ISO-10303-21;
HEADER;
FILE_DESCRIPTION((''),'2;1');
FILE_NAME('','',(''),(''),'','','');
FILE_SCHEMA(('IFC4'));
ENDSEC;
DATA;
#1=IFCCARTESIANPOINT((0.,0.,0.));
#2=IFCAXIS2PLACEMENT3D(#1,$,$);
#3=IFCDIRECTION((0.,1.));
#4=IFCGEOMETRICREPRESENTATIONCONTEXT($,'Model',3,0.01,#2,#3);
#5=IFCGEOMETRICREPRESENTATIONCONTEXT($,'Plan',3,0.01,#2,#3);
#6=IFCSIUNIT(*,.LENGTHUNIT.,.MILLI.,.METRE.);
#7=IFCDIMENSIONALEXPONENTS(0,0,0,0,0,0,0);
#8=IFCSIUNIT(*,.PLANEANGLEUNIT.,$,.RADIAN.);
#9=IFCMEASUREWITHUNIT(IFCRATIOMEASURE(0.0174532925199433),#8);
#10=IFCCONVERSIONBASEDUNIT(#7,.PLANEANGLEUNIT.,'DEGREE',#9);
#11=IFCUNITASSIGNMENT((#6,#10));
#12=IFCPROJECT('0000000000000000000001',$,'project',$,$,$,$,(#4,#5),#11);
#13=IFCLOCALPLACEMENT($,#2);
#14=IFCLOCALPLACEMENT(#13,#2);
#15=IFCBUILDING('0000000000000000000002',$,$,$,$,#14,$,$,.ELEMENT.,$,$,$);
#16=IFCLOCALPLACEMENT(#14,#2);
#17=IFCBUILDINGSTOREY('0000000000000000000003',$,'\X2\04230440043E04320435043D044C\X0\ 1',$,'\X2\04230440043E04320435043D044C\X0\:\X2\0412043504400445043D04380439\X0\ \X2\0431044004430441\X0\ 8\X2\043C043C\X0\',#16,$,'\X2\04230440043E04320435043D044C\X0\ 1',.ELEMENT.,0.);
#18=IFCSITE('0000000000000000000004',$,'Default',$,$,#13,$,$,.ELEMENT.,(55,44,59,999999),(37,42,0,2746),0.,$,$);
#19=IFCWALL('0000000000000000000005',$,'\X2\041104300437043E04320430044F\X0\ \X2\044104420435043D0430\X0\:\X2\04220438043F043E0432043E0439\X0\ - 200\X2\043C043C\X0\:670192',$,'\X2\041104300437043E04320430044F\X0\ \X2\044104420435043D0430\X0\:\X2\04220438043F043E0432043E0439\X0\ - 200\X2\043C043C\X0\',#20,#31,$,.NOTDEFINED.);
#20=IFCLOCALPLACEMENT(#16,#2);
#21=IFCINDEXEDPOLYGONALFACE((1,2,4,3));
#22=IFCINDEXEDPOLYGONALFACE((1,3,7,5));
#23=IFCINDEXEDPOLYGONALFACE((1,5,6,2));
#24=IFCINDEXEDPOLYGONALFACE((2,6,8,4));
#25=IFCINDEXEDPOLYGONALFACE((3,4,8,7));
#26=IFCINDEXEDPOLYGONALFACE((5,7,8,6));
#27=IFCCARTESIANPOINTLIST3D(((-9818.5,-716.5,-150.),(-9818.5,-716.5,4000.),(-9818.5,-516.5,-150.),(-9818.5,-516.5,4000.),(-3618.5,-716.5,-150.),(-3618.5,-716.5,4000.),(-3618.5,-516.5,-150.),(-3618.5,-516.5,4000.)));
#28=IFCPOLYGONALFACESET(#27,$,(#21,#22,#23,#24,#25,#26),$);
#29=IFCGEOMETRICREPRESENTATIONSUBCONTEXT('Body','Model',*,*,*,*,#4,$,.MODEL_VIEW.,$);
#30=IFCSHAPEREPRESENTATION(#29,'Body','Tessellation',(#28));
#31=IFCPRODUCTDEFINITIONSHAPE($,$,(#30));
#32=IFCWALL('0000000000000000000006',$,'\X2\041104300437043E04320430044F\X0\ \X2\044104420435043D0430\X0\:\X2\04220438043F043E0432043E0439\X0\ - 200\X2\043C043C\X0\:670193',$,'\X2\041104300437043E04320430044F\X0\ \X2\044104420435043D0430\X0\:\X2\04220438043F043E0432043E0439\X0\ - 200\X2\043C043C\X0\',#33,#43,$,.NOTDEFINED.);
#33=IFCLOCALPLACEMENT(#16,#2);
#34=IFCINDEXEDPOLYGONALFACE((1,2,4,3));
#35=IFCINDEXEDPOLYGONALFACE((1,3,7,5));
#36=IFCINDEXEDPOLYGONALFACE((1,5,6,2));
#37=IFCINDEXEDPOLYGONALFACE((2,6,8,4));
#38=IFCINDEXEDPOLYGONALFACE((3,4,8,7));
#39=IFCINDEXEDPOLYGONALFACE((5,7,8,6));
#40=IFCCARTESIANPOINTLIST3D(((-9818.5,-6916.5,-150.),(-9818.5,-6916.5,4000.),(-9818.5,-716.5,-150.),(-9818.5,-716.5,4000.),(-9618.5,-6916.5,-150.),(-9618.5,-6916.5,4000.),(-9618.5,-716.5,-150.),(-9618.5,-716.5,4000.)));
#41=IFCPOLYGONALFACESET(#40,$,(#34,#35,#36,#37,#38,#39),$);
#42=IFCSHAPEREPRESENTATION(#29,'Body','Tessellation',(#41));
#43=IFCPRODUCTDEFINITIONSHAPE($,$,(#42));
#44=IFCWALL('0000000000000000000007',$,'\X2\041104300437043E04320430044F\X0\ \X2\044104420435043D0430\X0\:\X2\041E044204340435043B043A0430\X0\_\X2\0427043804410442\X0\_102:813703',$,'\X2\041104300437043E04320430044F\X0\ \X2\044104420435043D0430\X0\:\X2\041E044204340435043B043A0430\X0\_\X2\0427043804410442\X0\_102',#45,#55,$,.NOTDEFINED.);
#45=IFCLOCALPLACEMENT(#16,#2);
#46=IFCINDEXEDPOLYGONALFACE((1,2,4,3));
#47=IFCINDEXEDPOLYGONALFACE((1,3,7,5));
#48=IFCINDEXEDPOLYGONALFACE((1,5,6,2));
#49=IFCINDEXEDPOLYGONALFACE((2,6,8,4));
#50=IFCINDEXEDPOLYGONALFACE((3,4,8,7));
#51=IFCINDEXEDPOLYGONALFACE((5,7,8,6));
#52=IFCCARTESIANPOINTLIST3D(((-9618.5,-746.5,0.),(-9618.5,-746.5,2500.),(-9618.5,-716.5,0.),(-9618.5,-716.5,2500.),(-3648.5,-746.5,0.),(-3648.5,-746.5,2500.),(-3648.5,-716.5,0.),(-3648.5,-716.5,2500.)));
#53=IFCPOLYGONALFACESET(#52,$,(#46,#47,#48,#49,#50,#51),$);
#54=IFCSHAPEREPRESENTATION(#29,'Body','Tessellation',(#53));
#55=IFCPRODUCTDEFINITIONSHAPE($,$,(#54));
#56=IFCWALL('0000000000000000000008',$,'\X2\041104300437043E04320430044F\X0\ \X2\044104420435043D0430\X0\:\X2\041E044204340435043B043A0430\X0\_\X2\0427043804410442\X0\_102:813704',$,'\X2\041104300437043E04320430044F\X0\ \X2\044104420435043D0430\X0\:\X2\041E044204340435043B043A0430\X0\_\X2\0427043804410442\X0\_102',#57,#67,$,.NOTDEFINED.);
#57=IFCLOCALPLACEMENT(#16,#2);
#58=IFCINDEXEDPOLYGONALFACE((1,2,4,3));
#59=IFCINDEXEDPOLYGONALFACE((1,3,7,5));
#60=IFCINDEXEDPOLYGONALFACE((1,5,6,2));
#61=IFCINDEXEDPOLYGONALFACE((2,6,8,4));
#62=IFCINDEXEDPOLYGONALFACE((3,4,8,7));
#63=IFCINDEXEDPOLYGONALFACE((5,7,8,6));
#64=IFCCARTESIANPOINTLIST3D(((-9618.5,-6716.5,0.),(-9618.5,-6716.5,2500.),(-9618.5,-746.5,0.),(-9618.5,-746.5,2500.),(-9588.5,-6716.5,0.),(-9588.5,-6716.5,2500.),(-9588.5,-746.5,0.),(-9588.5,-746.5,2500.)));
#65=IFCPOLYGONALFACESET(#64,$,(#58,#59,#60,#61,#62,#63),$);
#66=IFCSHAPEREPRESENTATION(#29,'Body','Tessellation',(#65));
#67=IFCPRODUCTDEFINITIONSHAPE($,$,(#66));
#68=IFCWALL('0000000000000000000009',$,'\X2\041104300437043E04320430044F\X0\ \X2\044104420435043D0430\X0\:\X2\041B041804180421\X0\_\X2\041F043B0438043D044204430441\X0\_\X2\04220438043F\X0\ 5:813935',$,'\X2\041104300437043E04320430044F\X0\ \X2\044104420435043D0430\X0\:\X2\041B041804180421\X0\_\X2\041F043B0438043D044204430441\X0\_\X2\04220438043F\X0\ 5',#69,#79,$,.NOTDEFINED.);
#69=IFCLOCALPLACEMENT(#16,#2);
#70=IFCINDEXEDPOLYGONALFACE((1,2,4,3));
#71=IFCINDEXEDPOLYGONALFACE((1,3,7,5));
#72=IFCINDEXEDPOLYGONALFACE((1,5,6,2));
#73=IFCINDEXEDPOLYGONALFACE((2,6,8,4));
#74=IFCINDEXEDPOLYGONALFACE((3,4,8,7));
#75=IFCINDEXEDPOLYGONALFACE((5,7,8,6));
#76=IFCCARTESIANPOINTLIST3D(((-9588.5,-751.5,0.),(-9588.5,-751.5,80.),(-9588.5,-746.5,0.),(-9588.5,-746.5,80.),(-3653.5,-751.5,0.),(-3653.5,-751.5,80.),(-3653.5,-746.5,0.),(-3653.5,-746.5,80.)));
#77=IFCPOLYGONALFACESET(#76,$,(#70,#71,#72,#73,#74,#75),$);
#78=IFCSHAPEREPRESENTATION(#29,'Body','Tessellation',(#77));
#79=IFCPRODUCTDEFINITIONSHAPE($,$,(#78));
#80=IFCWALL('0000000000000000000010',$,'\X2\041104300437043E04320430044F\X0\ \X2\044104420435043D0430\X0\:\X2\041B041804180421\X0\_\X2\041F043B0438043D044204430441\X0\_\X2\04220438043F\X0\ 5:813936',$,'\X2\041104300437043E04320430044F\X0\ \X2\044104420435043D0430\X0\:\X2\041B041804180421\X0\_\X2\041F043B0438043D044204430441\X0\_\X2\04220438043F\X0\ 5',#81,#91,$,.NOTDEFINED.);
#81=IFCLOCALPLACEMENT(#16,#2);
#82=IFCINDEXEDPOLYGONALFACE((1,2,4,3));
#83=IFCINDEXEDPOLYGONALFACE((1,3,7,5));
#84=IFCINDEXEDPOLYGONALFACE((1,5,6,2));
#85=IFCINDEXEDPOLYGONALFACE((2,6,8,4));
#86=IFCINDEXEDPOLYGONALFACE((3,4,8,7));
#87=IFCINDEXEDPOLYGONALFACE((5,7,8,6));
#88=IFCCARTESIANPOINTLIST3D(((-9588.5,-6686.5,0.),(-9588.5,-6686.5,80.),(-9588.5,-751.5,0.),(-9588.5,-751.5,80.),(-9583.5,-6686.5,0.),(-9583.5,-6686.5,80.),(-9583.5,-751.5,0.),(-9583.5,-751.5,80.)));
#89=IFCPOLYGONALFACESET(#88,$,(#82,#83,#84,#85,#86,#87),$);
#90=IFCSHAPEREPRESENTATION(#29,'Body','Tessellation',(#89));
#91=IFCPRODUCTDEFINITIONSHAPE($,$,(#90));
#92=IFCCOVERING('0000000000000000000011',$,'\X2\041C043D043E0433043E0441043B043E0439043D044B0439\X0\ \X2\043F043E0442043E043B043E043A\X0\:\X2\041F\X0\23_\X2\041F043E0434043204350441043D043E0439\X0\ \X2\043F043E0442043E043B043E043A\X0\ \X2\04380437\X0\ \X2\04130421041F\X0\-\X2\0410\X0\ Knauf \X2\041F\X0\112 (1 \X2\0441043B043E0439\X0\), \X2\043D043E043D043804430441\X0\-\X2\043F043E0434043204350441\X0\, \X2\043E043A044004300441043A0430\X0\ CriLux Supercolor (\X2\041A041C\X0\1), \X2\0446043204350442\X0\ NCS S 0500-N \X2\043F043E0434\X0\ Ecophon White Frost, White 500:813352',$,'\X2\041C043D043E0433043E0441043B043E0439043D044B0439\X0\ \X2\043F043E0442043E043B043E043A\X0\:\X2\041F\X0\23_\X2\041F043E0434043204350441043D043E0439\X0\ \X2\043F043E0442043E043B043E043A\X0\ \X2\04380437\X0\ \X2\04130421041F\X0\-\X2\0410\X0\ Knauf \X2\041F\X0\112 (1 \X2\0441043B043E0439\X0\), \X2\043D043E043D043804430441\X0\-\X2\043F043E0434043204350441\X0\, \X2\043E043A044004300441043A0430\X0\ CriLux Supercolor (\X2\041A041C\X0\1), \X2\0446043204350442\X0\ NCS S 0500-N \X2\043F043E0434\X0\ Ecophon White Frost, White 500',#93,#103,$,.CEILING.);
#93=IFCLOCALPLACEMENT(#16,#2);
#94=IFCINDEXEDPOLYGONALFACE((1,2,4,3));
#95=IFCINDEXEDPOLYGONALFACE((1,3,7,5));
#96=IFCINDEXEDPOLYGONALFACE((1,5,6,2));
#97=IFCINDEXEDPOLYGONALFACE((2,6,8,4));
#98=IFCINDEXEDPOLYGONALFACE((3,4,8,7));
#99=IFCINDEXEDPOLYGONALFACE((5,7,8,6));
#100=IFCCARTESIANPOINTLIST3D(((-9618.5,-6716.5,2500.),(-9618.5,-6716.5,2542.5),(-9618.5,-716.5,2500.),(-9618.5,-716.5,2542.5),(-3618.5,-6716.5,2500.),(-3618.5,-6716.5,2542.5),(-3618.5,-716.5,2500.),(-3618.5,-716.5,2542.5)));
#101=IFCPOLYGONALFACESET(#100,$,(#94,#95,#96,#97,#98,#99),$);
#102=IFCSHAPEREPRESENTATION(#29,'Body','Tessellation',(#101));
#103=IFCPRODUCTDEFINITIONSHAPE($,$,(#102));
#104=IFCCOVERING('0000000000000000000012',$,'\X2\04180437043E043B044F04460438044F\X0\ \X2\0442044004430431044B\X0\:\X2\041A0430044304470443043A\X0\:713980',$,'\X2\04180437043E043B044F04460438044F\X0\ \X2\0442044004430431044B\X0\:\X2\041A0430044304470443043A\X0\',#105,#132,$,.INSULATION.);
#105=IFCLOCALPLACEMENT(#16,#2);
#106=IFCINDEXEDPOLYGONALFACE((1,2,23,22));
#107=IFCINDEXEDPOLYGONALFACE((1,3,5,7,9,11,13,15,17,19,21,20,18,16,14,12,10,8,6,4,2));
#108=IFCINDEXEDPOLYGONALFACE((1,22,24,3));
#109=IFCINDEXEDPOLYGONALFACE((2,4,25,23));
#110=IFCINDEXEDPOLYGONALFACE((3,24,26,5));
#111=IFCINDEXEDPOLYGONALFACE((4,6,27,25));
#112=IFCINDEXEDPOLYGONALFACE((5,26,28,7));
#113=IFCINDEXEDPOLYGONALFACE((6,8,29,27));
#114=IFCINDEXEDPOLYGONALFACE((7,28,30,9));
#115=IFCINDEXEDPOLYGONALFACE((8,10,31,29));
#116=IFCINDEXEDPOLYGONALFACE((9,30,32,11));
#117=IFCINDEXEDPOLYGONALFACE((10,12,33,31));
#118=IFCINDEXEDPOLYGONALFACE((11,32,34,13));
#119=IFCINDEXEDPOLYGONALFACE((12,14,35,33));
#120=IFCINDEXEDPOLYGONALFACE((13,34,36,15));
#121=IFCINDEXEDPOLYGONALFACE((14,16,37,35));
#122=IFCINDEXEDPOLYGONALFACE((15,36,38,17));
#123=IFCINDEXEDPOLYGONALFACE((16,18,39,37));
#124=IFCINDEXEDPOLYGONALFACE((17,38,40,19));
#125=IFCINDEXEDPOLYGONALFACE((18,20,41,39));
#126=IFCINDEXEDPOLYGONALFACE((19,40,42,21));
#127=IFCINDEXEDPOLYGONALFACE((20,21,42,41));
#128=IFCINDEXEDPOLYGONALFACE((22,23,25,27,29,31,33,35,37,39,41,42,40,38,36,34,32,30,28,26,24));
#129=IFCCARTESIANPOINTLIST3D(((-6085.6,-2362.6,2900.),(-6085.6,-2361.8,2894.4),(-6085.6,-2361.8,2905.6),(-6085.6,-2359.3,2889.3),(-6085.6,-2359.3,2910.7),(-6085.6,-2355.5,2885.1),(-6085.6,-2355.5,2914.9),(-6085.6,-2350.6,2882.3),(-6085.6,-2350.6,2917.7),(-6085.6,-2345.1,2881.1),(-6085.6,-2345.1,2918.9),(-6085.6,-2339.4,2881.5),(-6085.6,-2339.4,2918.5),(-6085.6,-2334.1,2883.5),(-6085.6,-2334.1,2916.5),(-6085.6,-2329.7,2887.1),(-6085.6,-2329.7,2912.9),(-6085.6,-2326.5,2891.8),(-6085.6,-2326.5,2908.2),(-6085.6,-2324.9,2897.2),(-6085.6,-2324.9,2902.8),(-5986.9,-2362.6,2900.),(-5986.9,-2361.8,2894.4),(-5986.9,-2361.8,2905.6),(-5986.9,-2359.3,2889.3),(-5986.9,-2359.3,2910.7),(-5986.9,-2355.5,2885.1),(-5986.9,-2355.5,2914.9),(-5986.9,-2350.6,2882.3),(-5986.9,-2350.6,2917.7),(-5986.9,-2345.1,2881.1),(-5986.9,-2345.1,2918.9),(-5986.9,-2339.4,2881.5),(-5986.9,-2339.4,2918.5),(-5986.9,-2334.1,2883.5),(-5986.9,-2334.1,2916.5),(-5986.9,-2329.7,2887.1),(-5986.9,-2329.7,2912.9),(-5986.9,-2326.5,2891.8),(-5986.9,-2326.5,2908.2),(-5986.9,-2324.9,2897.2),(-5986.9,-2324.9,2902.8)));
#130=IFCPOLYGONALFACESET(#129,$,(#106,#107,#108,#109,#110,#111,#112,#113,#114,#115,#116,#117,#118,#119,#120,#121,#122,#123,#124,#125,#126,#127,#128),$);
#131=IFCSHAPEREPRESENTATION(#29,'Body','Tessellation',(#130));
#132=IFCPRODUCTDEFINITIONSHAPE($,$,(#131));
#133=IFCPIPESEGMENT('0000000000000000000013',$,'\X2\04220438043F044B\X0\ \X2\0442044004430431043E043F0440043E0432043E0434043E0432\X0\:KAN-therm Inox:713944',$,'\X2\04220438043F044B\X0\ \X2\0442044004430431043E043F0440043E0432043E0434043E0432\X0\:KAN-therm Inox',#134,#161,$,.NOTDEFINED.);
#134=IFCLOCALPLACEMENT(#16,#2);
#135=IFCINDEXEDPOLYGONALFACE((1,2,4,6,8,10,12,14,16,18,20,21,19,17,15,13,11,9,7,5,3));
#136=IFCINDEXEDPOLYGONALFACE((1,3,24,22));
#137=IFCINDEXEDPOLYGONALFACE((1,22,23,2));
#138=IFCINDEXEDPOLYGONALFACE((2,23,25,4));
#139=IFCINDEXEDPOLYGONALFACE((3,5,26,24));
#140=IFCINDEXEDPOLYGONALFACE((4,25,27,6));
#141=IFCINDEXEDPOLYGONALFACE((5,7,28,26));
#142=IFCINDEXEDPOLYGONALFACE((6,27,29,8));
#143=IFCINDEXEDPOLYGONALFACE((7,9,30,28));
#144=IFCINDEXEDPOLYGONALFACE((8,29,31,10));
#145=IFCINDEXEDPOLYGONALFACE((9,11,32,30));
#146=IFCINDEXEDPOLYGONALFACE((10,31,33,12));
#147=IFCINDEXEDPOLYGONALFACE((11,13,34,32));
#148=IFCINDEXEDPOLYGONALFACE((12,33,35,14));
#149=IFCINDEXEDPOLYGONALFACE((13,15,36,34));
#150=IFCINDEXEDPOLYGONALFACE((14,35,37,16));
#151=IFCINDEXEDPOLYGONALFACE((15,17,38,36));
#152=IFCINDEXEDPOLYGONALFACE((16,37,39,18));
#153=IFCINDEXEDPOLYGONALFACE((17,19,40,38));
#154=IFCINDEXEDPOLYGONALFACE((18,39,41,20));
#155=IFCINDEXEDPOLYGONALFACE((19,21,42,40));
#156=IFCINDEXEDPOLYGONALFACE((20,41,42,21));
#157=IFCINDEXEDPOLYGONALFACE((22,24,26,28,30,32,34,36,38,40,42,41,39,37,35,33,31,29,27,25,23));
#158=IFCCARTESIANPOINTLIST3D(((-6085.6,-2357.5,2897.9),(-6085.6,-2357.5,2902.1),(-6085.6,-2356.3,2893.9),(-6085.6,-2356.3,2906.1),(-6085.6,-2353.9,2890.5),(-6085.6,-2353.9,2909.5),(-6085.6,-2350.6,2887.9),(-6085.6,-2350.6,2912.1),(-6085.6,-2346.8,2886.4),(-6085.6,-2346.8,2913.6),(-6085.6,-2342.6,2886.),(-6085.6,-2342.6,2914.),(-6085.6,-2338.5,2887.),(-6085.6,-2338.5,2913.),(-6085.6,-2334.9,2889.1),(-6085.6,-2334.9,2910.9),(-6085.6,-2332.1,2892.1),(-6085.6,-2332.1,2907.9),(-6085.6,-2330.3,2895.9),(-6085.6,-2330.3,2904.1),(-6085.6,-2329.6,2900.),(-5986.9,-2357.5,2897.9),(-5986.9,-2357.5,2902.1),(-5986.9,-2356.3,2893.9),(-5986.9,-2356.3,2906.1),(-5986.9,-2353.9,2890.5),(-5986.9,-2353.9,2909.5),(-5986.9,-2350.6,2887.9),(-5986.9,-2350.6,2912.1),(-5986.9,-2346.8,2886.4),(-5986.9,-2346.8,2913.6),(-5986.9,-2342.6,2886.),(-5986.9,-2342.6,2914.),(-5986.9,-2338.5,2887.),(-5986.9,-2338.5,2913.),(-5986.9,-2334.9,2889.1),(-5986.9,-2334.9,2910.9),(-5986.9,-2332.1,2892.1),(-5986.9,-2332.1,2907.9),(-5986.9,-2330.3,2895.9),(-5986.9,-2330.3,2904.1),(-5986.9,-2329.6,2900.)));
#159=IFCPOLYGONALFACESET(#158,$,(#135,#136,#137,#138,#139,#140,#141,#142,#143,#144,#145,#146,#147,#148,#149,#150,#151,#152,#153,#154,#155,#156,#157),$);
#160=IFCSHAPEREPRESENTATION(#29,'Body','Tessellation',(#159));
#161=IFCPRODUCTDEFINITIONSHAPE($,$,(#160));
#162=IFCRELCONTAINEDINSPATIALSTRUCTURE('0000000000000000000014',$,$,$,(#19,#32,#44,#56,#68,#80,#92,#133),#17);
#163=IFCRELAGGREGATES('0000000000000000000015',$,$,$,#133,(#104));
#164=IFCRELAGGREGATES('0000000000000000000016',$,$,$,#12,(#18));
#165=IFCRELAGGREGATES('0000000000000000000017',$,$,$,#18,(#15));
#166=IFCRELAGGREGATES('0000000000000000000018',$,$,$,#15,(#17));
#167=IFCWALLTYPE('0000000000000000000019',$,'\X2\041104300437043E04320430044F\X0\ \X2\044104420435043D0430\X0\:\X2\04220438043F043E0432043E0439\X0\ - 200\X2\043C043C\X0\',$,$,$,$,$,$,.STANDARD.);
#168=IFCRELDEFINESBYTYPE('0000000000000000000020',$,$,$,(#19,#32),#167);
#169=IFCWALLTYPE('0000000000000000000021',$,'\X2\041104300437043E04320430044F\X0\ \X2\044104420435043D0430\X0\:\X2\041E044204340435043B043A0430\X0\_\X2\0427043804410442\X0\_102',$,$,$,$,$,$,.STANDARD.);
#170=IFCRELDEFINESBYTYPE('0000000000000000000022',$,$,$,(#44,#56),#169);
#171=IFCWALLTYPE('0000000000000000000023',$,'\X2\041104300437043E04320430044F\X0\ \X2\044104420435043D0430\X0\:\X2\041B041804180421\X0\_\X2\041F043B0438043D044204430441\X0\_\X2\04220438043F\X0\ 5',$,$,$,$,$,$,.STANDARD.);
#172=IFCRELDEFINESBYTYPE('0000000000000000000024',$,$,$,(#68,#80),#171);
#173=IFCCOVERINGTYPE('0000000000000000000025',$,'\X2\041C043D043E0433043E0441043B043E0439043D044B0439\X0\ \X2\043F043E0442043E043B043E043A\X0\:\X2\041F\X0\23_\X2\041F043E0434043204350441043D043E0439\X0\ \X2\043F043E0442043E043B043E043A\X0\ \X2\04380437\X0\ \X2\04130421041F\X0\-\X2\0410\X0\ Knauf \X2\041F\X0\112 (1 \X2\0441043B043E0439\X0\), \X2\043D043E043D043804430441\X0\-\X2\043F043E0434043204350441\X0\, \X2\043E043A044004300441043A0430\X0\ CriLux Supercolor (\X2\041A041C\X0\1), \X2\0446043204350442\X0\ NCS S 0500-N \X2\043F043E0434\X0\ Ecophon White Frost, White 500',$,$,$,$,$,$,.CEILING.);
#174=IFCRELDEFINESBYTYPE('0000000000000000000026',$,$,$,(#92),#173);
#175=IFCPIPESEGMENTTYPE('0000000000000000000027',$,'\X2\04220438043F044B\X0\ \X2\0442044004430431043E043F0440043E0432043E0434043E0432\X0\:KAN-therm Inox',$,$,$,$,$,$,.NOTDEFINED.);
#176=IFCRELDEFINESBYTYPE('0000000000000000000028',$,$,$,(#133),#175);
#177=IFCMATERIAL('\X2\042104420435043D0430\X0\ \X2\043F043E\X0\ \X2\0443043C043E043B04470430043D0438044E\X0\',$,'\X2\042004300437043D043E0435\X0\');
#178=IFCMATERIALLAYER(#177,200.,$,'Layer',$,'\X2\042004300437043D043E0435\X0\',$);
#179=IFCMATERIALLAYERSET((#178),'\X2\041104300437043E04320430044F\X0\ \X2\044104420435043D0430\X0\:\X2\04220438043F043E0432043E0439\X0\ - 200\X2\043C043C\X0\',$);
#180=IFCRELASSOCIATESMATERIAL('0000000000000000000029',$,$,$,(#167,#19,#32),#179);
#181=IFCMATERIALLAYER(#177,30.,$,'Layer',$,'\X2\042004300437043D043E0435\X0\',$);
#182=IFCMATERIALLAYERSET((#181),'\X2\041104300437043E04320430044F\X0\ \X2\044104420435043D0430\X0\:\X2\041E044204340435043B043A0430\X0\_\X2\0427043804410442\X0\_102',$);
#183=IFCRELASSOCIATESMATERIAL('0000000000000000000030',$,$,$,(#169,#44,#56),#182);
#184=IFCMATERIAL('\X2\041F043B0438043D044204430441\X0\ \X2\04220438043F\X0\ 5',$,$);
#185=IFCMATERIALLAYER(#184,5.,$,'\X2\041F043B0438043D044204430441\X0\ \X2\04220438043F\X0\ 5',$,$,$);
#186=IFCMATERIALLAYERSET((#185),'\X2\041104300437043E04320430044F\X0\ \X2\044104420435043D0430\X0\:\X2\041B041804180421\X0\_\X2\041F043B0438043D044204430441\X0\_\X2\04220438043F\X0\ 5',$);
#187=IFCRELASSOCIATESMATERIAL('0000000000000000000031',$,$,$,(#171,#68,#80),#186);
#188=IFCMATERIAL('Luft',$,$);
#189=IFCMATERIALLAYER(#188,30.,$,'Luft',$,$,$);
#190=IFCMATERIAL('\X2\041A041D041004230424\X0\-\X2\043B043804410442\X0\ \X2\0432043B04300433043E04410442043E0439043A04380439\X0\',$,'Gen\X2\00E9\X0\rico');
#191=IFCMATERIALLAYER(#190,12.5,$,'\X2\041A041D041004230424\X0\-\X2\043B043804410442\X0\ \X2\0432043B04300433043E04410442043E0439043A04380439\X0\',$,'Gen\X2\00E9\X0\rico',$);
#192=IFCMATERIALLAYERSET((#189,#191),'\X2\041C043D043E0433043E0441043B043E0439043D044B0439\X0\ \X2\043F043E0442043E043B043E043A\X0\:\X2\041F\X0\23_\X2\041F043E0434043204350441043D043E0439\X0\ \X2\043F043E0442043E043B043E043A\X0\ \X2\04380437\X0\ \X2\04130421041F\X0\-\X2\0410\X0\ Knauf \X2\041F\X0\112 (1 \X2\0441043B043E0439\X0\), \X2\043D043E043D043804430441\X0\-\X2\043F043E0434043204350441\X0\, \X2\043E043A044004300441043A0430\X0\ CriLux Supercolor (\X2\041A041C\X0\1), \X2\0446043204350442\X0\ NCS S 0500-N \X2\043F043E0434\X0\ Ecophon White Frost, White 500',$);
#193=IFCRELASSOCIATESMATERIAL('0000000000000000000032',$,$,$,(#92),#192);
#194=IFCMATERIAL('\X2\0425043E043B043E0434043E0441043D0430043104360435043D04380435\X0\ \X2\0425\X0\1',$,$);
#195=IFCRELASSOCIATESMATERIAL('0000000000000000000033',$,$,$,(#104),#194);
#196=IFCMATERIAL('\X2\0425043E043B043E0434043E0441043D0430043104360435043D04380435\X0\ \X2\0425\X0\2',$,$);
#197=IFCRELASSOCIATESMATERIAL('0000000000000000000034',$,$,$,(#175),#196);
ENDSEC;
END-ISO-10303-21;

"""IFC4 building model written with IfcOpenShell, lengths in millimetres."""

from ifc_helpers import new_model, entity, si_unit, converted_unit, direction, frame, frame_2d, origin, origin_2d_with_axis, place, context, subcontext, project, spatial, rectangle, circle, extrude, material, layer, layer_set, layer_usage, type_object, element, aggregate, save


model = new_model("IFC4")

# Units and contexts
model_context = context("Model", 3, precision=0.01, world=origin(), true_north=direction((0.0, 1.0)))
plan_context = context("Plan", 3, precision=0.01, world=origin(), true_north=direction((0.0, 1.0)))
body_context = subcontext(model_context, "Body", "Model", "MODEL_VIEW")
ifc_project = project(units=[si_unit("LENGTHUNIT", "METRE", prefix="MILLI"), converted_unit("PLANEANGLEUNIT", "DEGREE", entity("IfcRatioMeasure", 0.0174532925199433), si_unit("PLANEANGLEUNIT", "RADIAN"), dimensions=[0, 0, 0, 0, 0, 0, 0])], contexts=[model_context, plan_context])

# Site, building, storey
site_placement = place(None, origin())
site = spatial("IfcSite", under=ifc_project, at=site_placement, Name="Default", CompositionType="ELEMENT", RefLatitude=(55, 44, 59, 999999), RefLongitude=(37, 42, 0, 2746), RefElevation=0.0)
building_placement = place(site_placement, origin())
building = spatial("IfcBuilding", under=site, at=building_placement, CompositionType="ELEMENT")
storey_placement = place(building_placement, origin())
storey = spatial("IfcBuildingStorey", under=building, at=storey_placement, Name="Уровень 1", ObjectType="Уровень:Верхний брус 8мм", LongName="Уровень 1", CompositionType="ELEMENT", Elevation=0.0)

# Walls
ifc_material_1 = material(Name="Стена по умолчанию", Category="Разное")
ifc_layer_1 = layer(ifc_material_1, 200.0, Name="Layer", Category="Разное")
ifc_layer_set_1 = layer_set([ifc_layer_1], Name="Базовая стена:Типовой - 200мм")
ifc_layer_usage_1 = layer_usage(ifc_layer_set_1, "AXIS2", "NEGATIVE", 100.0)
wall_type_1 = type_object("IfcWallType", Name="Базовая стена:Типовой - 200мм", PredefinedType="STANDARD", material=ifc_layer_set_1)
wall_1_placement = place(storey_placement, frame((-9818.5, -616.5, -150.0)))
element("IfcWall", 1, at=wall_1_placement, inside=storey, type_object=wall_type_1, material=ifc_layer_usage_1, Name="Базовая стена:Типовой - 200мм:670192", ObjectType="Базовая стена:Типовой - 200мм", PredefinedType="NOTDEFINED", context=body_context, shape_type="SweptSolid", body=[
    extrude(rectangle(XDim=6200.0, YDim=200.0, at=frame_2d((3100.0, 0.0), x_axis=(-1.0, 0.0))), origin(), (0.0, 0.0, 1.0), 4150.0),
])
ifc_layer_usage_2 = layer_usage(ifc_layer_set_1, "AXIS2", "NEGATIVE", 100.0)
wall_2_placement = place(storey_placement, frame((-9718.5, -6916.5, -150.0), z_axis=(0.0, 0.0, 1.0), x_axis=(0.0, 1.0, 0.0)))
element("IfcWall", 2, at=wall_2_placement, inside=storey, type_object=wall_type_1, material=ifc_layer_usage_2, Name="Базовая стена:Типовой - 200мм:670193", ObjectType="Базовая стена:Типовой - 200мм", PredefinedType="NOTDEFINED", context=body_context, shape_type="SweptSolid", body=[
    extrude(rectangle(XDim=6200.0, YDim=200.0, at=frame_2d((3100.0, 0.0), x_axis=(-1.0, 0.0))), origin(), (0.0, 0.0, 1.0), 4150.0),
])
ifc_layer_2 = layer(ifc_material_1, 30.0, Name="Layer", Category="Разное")
ifc_layer_set_2 = layer_set([ifc_layer_2], Name="Базовая стена:Отделка_Чист_102")
ifc_layer_usage_3 = layer_usage(ifc_layer_set_2, "AXIS2", "POSITIVE", -15.0)
wall_type_2 = type_object("IfcWallType", Name="Базовая стена:Отделка_Чист_102", PredefinedType="STANDARD", material=ifc_layer_set_2)
wall_3_placement = place(storey_placement, frame((-9618.5, -731.5, 0.0)))
element("IfcWall", 3, at=wall_3_placement, inside=storey, type_object=wall_type_2, material=ifc_layer_usage_3, Name="Базовая стена:Отделка_Чист_102:813703", ObjectType="Базовая стена:Отделка_Чист_102", PredefinedType="NOTDEFINED", context=body_context, shape_type="SweptSolid", body=[
    extrude(rectangle(XDim=5970.0, YDim=30.0, at=frame_2d((2985.0, 0.0), x_axis=(-1.0, 0.0))), origin(), (0.0, 0.0, 1.0), 2500.0),
])
ifc_layer_usage_4 = layer_usage(ifc_layer_set_2, "AXIS2", "POSITIVE", -15.0)
wall_4_placement = place(storey_placement, frame((-9603.5, -6716.5, 0.0), z_axis=(0.0, 0.0, 1.0), x_axis=(0.0, 1.0, 0.0)))
element("IfcWall", 4, at=wall_4_placement, inside=storey, type_object=wall_type_2, material=ifc_layer_usage_4, Name="Базовая стена:Отделка_Чист_102:813704", ObjectType="Базовая стена:Отделка_Чист_102", PredefinedType="NOTDEFINED", context=body_context, shape_type="SweptSolid", body=[
    extrude(rectangle(XDim=5970.0, YDim=30.0, at=frame_2d((2985.0, 0.0), x_axis=(-1.0, 0.0))), origin(), (0.0, 0.0, 1.0), 2500.0),
])
ifc_material_2 = material(Name="Плинтус Тип 5")
ifc_layer_3 = layer(ifc_material_2, 5.0, Name="Плинтус Тип 5")
ifc_layer_set_3 = layer_set([ifc_layer_3], Name="Базовая стена:ЛИИС_Плинтус_Тип 5")
ifc_layer_usage_5 = layer_usage(ifc_layer_set_3, "AXIS2", "NEGATIVE", 2.5)
wall_type_3 = type_object("IfcWallType", Name="Базовая стена:ЛИИС_Плинтус_Тип 5", PredefinedType="STANDARD", material=ifc_layer_set_3)
wall_5_placement = place(storey_placement, frame((-9588.5, -749.0, 0.0)))
element("IfcWall", 5, at=wall_5_placement, inside=storey, type_object=wall_type_3, material=ifc_layer_usage_5, Name="Базовая стена:ЛИИС_Плинтус_Тип 5:813935", ObjectType="Базовая стена:ЛИИС_Плинтус_Тип 5", PredefinedType="NOTDEFINED", context=body_context, shape_type="SweptSolid", body=[
    extrude(rectangle(XDim=5935.0, YDim=5.0, at=frame_2d((2967.5, 0.0), x_axis=(-1.0, 0.0))), origin(), (0.0, 0.0, 1.0), 80.0),
])
ifc_layer_usage_6 = layer_usage(ifc_layer_set_3, "AXIS2", "NEGATIVE", 2.5)
wall_6_placement = place(storey_placement, frame((-9586.0, -6686.5, 0.0), z_axis=(0.0, 0.0, 1.0), x_axis=(0.0, 1.0, 0.0)))
element("IfcWall", 6, at=wall_6_placement, inside=storey, type_object=wall_type_3, material=ifc_layer_usage_6, Name="Базовая стена:ЛИИС_Плинтус_Тип 5:813936", ObjectType="Базовая стена:ЛИИС_Плинтус_Тип 5", PredefinedType="NOTDEFINED", context=body_context, shape_type="SweptSolid", body=[
    extrude(rectangle(XDim=5935.0, YDim=5.0, at=frame_2d((2967.5, 0.0), x_axis=(-1.0, 0.0))), origin(), (0.0, 0.0, 1.0), 80.0),
])

# Coverings
ifc_material_3 = material(Name="Luft")
ifc_layer_4 = layer(ifc_material_3, 30.0, Name="Luft")
ifc_material_4 = material(Name="КНАУФ-лист влагостойкий", Category="Genérico")
ifc_layer_5 = layer(ifc_material_4, 12.5, Name="КНАУФ-лист влагостойкий", Category="Genérico")
ifc_layer_set_4 = layer_set([ifc_layer_4, ifc_layer_5], Name="Многослойный потолок:П23_Подвесной потолок из ГСП-А Knauf П112 (1 слой), нониус-подвес, окраска CriLux Supercolor (КМ1), цвет NCS S 0500-N под Ecophon White Frost, White 500")
ifc_layer_usage_7 = layer_usage(ifc_layer_set_4, "AXIS3", "POSITIVE", 0.0)
covering_type = type_object("IfcCoveringType", Name="Многослойный потолок:П23_Подвесной потолок из ГСП-А Knauf П112 (1 слой), нониус-подвес, окраска CriLux Supercolor (КМ1), цвет NCS S 0500-N под Ecophon White Frost, White 500", PredefinedType="CEILING")
covering_1_placement = place(storey_placement, frame((-9618.5, -6716.5, 2500.0)))
element("IfcCovering", 7, at=covering_1_placement, inside=storey, type_object=covering_type, material=ifc_layer_usage_7, Name="Многослойный потолок:П23_Подвесной потолок из ГСП-А Knauf П112 (1 слой), нониус-подвес, окраска CriLux Supercolor (КМ1), цвет NCS S 0500-N под Ecophon White Frost, White 500:813352", ObjectType="Многослойный потолок:П23_Подвесной потолок из ГСП-А Knauf П112 (1 слой), нониус-подвес, окраска CriLux Supercolor (КМ1), цвет NCS S 0500-N под Ecophon White Frost, White 500", PredefinedType="CEILING", context=body_context, shape_type="SweptSolid", body=[
    extrude(rectangle(XDim=6000.0, YDim=6000.0, at=origin_2d_with_axis()), frame((3000.0, 3000.0, 0.0), z_axis=(0.0, 0.0, 1.0), x_axis=(0.0, -1.0, 0.0)), (0.0, 0.0, 1.0), 42.5),
])
ifc_material_5 = material(Name="Холодоснабжение Х1")
covering_2_placement = place(storey_placement, frame((-6085.6, -2364.2, 2879.4)))
covering_2 = element("IfcCovering", 8, at=covering_2_placement, material=ifc_material_5, Name="Изоляция трубы:Каучук:713980", ObjectType="Изоляция трубы:Каучук", PredefinedType="INSULATION", context=body_context, shape_type="SweptSolid", body=[
    extrude(circle(Radius=19.0, at=frame_2d((0.0, 0.0), x_axis=(1.0, 0.0))), frame((0.0, 20.6, 20.6), z_axis=(1.0, 0.0, 0.0), x_axis=(0.0, -1.0, 0.0)), (0.0, 0.0, 1.0), 98.6),
])
ifc_material_6 = material(Name="Холодоснабжение Х2")

# Pipe segment
pipe_segment_type_1 = type_object("IfcPipeSegmentType", Name="Типы трубопроводов:KAN-therm Inox", PredefinedType="NOTDEFINED", material=ifc_material_6)
pipe_segment_1_placement = place(storey_placement, frame((-6085.6, -2359.2, 2884.4)))
pipe_segment_1 = element("IfcPipeSegment", 9, at=pipe_segment_1_placement, inside=storey, type_object=pipe_segment_type_1, Name="Типы трубопроводов:KAN-therm Inox:713944", ObjectType="Типы трубопроводов:KAN-therm Inox", PredefinedType="NOTDEFINED", context=body_context, shape_type="SweptSolid", body=[
    extrude(circle(Radius=14.0, at=frame_2d((0.0, 0.0), x_axis=(1.0, 0.0))), frame((0.0, 15.6, 15.6), z_axis=(1.0, 0.0, 0.0), x_axis=(0.0, 1.0, 0.0)), (0.0, 0.0, 1.0), 98.6),
])
aggregate(pipe_segment_1, [covering_2])

save(model, "model.ifc")
